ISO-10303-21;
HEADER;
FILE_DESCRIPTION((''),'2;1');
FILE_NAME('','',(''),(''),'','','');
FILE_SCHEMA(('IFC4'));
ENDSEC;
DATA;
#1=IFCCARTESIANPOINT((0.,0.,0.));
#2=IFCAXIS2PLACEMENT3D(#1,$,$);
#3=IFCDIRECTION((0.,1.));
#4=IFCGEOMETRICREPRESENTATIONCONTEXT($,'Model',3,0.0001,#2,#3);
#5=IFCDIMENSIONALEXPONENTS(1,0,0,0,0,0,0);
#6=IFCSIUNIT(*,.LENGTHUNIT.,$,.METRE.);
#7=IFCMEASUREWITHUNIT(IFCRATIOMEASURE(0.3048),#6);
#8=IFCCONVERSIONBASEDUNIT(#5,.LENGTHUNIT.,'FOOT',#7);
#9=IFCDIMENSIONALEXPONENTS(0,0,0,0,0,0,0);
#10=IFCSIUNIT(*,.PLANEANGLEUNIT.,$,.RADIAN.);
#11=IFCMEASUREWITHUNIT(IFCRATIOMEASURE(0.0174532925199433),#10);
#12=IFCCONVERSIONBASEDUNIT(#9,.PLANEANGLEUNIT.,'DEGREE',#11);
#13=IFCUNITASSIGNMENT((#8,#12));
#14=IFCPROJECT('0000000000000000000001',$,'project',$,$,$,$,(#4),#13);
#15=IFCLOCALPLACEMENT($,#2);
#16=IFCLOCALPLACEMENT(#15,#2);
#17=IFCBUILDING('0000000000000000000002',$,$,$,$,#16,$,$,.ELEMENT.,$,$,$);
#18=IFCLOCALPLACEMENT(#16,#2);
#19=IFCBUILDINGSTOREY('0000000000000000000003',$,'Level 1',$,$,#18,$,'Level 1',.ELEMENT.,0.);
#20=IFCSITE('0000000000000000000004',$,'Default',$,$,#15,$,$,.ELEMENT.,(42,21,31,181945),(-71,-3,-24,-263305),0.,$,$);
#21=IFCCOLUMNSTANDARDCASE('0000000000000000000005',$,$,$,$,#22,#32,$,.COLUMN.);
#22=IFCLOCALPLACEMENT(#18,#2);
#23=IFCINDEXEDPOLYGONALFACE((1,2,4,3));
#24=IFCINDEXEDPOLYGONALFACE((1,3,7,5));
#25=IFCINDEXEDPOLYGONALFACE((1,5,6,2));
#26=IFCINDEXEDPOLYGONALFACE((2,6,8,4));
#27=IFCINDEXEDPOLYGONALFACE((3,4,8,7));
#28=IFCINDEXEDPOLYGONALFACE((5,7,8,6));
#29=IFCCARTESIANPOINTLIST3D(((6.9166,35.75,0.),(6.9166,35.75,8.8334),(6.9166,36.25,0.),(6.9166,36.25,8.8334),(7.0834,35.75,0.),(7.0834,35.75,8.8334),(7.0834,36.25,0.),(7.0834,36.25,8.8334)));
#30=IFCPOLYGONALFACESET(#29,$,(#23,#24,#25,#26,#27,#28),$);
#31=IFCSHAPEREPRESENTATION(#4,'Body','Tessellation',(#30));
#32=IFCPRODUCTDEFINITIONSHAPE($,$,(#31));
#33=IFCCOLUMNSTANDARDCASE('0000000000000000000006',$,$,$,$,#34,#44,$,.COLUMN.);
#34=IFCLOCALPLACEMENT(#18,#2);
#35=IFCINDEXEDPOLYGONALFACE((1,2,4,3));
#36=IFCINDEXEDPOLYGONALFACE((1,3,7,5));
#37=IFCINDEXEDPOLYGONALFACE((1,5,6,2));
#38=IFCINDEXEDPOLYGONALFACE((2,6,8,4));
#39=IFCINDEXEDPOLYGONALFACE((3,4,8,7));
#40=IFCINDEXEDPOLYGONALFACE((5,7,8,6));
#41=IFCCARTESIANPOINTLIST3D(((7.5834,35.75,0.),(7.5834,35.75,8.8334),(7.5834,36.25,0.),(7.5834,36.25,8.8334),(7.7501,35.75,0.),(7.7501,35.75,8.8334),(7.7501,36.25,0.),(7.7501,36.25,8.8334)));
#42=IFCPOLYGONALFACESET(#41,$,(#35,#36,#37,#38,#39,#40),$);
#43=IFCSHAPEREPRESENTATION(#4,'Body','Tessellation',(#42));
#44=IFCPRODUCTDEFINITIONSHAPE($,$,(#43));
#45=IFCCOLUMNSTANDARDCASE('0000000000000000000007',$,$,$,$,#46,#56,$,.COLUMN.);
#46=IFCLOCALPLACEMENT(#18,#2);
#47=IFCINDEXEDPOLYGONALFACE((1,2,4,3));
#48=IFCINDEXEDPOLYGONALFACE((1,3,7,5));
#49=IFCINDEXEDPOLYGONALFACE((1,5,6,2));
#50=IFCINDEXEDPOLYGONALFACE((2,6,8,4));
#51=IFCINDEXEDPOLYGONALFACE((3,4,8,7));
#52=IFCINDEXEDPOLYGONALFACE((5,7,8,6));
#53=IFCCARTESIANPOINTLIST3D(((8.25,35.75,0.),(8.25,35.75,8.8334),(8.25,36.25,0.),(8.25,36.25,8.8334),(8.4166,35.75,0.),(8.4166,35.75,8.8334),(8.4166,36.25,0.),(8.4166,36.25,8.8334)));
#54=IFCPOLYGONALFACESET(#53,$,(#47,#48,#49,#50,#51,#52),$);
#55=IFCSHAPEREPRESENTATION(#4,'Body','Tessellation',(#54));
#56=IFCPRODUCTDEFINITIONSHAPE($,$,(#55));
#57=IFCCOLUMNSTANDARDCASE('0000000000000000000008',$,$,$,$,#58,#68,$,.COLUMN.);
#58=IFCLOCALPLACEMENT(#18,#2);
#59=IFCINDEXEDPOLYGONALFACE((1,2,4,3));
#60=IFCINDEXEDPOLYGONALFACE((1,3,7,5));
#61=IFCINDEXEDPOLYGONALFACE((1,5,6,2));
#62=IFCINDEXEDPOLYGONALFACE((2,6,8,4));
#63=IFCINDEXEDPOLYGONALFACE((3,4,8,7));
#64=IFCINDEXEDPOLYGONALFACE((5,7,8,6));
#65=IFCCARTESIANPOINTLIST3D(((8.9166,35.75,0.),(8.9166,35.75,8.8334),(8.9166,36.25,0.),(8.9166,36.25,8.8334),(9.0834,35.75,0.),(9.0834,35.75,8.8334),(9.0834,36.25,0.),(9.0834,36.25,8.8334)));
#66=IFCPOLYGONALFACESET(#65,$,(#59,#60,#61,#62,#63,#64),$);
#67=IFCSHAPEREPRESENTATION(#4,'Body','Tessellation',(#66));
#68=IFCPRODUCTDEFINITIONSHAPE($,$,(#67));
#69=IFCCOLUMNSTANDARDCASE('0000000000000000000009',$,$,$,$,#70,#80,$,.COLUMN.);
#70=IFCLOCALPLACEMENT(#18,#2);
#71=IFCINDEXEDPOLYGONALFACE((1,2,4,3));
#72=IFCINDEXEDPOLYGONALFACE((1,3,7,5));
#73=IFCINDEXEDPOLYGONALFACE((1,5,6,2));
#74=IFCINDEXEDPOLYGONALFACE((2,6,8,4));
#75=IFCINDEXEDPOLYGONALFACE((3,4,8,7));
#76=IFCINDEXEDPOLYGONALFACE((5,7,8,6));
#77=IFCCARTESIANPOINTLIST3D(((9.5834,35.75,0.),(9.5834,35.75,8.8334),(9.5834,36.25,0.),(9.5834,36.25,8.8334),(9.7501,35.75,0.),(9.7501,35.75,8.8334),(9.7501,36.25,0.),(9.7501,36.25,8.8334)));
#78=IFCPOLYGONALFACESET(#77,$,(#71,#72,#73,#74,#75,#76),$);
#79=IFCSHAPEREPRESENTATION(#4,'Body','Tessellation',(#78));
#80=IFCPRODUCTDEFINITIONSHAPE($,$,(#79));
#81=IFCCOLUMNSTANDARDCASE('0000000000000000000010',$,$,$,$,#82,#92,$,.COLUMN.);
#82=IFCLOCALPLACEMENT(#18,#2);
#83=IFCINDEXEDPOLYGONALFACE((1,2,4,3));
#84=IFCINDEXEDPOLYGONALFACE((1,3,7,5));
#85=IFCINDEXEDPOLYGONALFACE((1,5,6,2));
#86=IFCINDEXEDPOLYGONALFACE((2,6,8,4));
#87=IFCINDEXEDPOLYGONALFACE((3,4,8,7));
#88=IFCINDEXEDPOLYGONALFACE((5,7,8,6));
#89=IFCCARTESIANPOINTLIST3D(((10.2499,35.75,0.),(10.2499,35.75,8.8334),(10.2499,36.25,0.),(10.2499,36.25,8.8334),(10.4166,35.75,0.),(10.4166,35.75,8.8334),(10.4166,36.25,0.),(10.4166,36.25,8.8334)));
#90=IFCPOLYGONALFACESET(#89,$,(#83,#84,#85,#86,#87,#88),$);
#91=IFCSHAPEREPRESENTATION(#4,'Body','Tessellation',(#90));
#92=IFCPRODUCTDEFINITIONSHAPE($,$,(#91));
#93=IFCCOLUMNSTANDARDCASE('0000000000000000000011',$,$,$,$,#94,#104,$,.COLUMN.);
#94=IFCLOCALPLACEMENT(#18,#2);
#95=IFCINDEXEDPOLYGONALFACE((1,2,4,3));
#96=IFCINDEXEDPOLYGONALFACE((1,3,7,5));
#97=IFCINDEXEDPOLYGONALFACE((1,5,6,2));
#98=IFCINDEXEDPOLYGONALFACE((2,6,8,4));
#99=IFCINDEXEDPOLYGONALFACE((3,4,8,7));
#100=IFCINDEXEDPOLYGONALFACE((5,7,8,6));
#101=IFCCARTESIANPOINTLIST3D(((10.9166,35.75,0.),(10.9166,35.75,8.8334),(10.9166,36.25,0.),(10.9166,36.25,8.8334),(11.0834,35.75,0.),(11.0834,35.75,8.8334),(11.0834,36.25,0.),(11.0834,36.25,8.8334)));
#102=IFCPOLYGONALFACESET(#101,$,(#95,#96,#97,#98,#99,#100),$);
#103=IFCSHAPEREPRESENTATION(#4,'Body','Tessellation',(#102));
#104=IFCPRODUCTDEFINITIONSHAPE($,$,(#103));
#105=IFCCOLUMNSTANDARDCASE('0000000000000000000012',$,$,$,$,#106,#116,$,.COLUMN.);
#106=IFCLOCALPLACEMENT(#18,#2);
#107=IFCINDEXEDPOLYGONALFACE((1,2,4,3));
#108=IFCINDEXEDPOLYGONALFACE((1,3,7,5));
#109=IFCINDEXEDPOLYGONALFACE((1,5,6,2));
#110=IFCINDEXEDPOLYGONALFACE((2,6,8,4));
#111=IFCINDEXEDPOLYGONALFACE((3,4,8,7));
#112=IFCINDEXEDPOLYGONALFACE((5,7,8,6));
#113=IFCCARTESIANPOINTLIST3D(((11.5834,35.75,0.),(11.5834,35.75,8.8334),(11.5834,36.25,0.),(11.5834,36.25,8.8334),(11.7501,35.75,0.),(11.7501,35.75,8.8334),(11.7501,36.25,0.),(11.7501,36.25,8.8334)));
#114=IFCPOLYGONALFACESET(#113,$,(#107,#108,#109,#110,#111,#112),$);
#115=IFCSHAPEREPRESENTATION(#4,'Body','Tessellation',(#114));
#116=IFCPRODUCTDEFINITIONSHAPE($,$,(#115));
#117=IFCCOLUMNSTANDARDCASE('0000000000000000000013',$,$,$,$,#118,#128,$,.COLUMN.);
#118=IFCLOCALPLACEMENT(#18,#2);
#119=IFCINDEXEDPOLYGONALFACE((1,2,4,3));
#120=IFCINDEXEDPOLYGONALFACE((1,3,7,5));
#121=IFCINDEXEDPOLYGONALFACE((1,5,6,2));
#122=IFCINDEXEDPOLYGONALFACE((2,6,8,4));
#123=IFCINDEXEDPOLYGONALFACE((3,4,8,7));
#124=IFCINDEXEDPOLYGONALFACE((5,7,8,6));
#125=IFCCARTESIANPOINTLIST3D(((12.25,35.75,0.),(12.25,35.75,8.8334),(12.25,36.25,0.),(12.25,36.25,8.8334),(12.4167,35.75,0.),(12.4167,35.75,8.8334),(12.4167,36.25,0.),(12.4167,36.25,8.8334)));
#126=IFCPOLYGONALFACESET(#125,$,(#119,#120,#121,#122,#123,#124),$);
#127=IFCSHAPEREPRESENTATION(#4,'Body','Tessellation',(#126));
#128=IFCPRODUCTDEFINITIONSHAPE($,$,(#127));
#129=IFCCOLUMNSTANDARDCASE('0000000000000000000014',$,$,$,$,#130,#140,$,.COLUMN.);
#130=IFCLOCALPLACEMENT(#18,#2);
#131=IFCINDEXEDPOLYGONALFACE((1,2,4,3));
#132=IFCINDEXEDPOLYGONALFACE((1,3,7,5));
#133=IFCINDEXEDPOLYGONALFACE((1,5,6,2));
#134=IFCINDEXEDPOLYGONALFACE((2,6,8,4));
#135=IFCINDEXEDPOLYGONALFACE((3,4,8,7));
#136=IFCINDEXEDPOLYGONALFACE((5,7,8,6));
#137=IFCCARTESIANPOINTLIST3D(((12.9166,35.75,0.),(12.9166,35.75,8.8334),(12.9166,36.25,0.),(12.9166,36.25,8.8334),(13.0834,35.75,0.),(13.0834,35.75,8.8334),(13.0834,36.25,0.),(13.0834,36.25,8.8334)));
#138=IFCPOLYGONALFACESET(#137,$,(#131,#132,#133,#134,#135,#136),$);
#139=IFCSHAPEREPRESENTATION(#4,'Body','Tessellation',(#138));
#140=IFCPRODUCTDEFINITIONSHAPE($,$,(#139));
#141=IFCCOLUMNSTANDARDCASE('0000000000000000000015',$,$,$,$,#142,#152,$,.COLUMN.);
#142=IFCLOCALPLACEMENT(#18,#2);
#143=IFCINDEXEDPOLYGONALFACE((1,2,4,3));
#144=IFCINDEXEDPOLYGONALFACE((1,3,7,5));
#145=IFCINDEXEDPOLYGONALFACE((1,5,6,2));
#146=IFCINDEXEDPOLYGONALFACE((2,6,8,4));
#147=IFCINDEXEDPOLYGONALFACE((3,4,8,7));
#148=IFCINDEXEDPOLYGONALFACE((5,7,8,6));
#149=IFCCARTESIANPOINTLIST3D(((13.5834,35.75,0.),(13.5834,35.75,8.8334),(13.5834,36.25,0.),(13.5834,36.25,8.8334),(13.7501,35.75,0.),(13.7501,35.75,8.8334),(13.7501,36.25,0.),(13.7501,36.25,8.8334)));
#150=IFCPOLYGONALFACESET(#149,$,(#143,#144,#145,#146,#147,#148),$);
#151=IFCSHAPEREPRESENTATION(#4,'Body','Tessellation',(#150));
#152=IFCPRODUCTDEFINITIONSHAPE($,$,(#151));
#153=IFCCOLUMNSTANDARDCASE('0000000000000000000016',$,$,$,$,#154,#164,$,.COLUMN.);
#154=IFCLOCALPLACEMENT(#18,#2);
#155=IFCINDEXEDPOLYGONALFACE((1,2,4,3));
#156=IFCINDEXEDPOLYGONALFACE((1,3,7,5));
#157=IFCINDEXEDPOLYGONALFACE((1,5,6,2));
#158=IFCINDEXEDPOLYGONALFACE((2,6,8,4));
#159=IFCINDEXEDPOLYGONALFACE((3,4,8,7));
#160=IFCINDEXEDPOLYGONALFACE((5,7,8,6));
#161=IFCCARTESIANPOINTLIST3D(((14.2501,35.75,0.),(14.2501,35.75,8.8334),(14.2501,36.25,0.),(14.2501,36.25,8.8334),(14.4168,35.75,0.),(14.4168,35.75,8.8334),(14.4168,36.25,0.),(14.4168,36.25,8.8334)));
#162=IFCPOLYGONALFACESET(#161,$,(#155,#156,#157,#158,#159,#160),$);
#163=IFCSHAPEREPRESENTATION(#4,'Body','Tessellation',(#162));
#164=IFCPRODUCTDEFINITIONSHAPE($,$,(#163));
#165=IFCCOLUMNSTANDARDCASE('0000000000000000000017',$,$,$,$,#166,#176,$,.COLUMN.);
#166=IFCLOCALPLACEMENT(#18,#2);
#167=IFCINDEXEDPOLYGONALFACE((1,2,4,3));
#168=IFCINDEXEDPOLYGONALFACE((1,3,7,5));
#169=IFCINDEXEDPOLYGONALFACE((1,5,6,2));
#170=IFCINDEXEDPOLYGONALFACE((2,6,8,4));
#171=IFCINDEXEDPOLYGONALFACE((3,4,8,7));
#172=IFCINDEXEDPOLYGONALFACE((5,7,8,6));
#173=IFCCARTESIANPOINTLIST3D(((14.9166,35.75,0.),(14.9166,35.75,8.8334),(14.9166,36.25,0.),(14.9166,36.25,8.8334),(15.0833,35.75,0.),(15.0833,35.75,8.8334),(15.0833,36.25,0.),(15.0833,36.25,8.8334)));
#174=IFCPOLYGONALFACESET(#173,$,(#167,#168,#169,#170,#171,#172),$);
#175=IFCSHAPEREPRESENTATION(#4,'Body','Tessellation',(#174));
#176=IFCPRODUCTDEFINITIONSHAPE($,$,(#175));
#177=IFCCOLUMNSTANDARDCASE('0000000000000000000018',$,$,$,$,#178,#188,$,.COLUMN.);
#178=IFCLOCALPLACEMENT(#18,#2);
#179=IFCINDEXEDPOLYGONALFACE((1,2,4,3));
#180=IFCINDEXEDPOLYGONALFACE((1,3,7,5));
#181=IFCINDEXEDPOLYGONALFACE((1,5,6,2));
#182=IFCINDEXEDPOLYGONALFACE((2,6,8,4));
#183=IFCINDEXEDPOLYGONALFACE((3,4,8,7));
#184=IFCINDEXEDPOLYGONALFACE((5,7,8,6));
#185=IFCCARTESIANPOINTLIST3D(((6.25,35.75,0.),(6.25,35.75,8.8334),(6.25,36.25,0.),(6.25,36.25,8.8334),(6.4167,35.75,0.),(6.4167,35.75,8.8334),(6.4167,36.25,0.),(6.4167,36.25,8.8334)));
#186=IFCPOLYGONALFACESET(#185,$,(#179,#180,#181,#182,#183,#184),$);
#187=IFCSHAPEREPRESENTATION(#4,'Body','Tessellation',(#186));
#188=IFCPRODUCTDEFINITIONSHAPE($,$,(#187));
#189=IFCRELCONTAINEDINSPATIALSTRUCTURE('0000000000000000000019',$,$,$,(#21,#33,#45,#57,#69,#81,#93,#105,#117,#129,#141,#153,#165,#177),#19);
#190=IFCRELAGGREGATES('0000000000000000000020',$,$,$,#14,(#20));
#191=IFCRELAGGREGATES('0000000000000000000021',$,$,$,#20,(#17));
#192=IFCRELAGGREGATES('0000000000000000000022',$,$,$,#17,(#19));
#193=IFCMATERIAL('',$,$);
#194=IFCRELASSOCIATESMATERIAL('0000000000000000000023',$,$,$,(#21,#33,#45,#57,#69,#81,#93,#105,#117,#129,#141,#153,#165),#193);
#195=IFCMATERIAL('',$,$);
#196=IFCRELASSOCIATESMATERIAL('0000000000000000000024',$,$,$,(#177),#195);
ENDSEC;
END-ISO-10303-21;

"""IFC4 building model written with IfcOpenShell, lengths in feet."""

from ifc_helpers import new_model, entity, si_unit, converted_unit, direction, frame, origin, place, context, project, spatial, rectangle, extrude, material, element, save


model = new_model("IFC4")

# Units and contexts
model_context = context("Model", 3, precision=0.0001, world=origin(), true_north=direction((0.0, 1.0)))
ifc_project = project(units=[converted_unit("LENGTHUNIT", "FOOT", entity("IfcRatioMeasure", 0.3048), si_unit("LENGTHUNIT", "METRE"), dimensions=[1, 0, 0, 0, 0, 0, 0]), converted_unit("PLANEANGLEUNIT", "DEGREE", entity("IfcRatioMeasure", 0.0174532925199433), si_unit("PLANEANGLEUNIT", "RADIAN"), dimensions=[0, 0, 0, 0, 0, 0, 0])], contexts=[model_context])

# Site, building, storey
site_placement = place(None, origin())
site = spatial("IfcSite", under=ifc_project, at=site_placement, Name="Default", CompositionType="ELEMENT", RefLatitude=(42, 21, 31, 181945), RefLongitude=(-71, -3, -24, -263305), RefElevation=0.0)
building_placement = place(site_placement, origin())
building = spatial("IfcBuilding", under=site, at=building_placement, CompositionType="ELEMENT")
storey_placement = place(building_placement, origin())
storey = spatial("IfcBuildingStorey", under=building, at=storey_placement, Name="Level 1", LongName="Level 1", CompositionType="ELEMENT", Elevation=0.0)

# Columns
ifc_material_1 = material(Name="")
placement = place(storey_placement, frame((0.25, 36.0, 0.0)))
for number, where, z_axis, x_axis in (
    (1, (6.75, 0.0, 0.0), (0.0, 0.0, 1.0), (1.0, 0.0, 0.0)),
    (2, (7.4167, 0.0, 0.0), (0.0, 0.0, 1.0), (1.0, 0.0, 0.0)),
    (3, (8.0833, 0.0, 0.0), (0.0, 0.0, 1.0), (1.0, 0.0, 0.0)),
    (4, (8.75, 0.0, 0.0), (0.0, 0.0, 1.0), (1.0, 0.0, 0.0)),
    (5, (9.4167, 0.0, 0.0), (0.0, 0.0, 1.0), (1.0, 0.0, 0.0)),
    (6, (10.0833, 0.0, 0.0), (0.0, 0.0, 1.0), (1.0, 0.0, 0.0)),
    (7, (10.75, 0.0, 0.0), (0.0, 0.0, 1.0), (1.0, 0.0, 0.0)),
    (8, (11.4167, 0.0, 0.0), (0.0, 0.0, 1.0), (1.0, 0.0, 0.0)),
    (9, (12.0834, 0.0, 0.0), (0.0, 0.0, 1.0), (1.0, 0.0, 0.0)),
    (10, (12.75, 0.0, 0.0), (0.0, 0.0, 1.0), (1.0, 0.0, 0.0)),
    (11, (13.4167, 0.0, 0.0), (0.0, 0.0, 1.0), (1.0, 0.0, 0.0)),
    (12, (14.0834, 0.0, 0.0), (0.0, 0.0, 1.0), (1.0, 0.0, 0.0)),
    (13, (14.75, 0.0, 0.0), (0.0, 0.0, 1.0), (1.0, 0.0, 0.0)),
):
    element("IfcColumnStandardCase", number, at=place(placement, frame(where, z_axis=z_axis, x_axis=x_axis)), inside=storey, material=ifc_material_1, PredefinedType="COLUMN", context=model_context, shape_type="SweptSolid", body=[
        extrude(rectangle(XDim=0.1667, YDim=0.5), origin(), (0.0, 0.0, 1.0), 8.8334),
    ])
ifc_material_2 = material(Name="")
for number, where, z_axis, x_axis in (
    (14, (6.0833, 0.0, 0.0), (0.0, 0.0, 1.0), (1.0, 0.0, 0.0)),
):
    element("IfcColumnStandardCase", number, at=place(placement, frame(where, z_axis=z_axis, x_axis=x_axis)), inside=storey, material=ifc_material_2, PredefinedType="COLUMN", context=model_context, shape_type="SweptSolid", body=[
        extrude(rectangle(XDim=0.1667, YDim=0.5), origin(), (0.0, 0.0, 1.0), 8.8334),
    ])

save(model, "model.ifc")
